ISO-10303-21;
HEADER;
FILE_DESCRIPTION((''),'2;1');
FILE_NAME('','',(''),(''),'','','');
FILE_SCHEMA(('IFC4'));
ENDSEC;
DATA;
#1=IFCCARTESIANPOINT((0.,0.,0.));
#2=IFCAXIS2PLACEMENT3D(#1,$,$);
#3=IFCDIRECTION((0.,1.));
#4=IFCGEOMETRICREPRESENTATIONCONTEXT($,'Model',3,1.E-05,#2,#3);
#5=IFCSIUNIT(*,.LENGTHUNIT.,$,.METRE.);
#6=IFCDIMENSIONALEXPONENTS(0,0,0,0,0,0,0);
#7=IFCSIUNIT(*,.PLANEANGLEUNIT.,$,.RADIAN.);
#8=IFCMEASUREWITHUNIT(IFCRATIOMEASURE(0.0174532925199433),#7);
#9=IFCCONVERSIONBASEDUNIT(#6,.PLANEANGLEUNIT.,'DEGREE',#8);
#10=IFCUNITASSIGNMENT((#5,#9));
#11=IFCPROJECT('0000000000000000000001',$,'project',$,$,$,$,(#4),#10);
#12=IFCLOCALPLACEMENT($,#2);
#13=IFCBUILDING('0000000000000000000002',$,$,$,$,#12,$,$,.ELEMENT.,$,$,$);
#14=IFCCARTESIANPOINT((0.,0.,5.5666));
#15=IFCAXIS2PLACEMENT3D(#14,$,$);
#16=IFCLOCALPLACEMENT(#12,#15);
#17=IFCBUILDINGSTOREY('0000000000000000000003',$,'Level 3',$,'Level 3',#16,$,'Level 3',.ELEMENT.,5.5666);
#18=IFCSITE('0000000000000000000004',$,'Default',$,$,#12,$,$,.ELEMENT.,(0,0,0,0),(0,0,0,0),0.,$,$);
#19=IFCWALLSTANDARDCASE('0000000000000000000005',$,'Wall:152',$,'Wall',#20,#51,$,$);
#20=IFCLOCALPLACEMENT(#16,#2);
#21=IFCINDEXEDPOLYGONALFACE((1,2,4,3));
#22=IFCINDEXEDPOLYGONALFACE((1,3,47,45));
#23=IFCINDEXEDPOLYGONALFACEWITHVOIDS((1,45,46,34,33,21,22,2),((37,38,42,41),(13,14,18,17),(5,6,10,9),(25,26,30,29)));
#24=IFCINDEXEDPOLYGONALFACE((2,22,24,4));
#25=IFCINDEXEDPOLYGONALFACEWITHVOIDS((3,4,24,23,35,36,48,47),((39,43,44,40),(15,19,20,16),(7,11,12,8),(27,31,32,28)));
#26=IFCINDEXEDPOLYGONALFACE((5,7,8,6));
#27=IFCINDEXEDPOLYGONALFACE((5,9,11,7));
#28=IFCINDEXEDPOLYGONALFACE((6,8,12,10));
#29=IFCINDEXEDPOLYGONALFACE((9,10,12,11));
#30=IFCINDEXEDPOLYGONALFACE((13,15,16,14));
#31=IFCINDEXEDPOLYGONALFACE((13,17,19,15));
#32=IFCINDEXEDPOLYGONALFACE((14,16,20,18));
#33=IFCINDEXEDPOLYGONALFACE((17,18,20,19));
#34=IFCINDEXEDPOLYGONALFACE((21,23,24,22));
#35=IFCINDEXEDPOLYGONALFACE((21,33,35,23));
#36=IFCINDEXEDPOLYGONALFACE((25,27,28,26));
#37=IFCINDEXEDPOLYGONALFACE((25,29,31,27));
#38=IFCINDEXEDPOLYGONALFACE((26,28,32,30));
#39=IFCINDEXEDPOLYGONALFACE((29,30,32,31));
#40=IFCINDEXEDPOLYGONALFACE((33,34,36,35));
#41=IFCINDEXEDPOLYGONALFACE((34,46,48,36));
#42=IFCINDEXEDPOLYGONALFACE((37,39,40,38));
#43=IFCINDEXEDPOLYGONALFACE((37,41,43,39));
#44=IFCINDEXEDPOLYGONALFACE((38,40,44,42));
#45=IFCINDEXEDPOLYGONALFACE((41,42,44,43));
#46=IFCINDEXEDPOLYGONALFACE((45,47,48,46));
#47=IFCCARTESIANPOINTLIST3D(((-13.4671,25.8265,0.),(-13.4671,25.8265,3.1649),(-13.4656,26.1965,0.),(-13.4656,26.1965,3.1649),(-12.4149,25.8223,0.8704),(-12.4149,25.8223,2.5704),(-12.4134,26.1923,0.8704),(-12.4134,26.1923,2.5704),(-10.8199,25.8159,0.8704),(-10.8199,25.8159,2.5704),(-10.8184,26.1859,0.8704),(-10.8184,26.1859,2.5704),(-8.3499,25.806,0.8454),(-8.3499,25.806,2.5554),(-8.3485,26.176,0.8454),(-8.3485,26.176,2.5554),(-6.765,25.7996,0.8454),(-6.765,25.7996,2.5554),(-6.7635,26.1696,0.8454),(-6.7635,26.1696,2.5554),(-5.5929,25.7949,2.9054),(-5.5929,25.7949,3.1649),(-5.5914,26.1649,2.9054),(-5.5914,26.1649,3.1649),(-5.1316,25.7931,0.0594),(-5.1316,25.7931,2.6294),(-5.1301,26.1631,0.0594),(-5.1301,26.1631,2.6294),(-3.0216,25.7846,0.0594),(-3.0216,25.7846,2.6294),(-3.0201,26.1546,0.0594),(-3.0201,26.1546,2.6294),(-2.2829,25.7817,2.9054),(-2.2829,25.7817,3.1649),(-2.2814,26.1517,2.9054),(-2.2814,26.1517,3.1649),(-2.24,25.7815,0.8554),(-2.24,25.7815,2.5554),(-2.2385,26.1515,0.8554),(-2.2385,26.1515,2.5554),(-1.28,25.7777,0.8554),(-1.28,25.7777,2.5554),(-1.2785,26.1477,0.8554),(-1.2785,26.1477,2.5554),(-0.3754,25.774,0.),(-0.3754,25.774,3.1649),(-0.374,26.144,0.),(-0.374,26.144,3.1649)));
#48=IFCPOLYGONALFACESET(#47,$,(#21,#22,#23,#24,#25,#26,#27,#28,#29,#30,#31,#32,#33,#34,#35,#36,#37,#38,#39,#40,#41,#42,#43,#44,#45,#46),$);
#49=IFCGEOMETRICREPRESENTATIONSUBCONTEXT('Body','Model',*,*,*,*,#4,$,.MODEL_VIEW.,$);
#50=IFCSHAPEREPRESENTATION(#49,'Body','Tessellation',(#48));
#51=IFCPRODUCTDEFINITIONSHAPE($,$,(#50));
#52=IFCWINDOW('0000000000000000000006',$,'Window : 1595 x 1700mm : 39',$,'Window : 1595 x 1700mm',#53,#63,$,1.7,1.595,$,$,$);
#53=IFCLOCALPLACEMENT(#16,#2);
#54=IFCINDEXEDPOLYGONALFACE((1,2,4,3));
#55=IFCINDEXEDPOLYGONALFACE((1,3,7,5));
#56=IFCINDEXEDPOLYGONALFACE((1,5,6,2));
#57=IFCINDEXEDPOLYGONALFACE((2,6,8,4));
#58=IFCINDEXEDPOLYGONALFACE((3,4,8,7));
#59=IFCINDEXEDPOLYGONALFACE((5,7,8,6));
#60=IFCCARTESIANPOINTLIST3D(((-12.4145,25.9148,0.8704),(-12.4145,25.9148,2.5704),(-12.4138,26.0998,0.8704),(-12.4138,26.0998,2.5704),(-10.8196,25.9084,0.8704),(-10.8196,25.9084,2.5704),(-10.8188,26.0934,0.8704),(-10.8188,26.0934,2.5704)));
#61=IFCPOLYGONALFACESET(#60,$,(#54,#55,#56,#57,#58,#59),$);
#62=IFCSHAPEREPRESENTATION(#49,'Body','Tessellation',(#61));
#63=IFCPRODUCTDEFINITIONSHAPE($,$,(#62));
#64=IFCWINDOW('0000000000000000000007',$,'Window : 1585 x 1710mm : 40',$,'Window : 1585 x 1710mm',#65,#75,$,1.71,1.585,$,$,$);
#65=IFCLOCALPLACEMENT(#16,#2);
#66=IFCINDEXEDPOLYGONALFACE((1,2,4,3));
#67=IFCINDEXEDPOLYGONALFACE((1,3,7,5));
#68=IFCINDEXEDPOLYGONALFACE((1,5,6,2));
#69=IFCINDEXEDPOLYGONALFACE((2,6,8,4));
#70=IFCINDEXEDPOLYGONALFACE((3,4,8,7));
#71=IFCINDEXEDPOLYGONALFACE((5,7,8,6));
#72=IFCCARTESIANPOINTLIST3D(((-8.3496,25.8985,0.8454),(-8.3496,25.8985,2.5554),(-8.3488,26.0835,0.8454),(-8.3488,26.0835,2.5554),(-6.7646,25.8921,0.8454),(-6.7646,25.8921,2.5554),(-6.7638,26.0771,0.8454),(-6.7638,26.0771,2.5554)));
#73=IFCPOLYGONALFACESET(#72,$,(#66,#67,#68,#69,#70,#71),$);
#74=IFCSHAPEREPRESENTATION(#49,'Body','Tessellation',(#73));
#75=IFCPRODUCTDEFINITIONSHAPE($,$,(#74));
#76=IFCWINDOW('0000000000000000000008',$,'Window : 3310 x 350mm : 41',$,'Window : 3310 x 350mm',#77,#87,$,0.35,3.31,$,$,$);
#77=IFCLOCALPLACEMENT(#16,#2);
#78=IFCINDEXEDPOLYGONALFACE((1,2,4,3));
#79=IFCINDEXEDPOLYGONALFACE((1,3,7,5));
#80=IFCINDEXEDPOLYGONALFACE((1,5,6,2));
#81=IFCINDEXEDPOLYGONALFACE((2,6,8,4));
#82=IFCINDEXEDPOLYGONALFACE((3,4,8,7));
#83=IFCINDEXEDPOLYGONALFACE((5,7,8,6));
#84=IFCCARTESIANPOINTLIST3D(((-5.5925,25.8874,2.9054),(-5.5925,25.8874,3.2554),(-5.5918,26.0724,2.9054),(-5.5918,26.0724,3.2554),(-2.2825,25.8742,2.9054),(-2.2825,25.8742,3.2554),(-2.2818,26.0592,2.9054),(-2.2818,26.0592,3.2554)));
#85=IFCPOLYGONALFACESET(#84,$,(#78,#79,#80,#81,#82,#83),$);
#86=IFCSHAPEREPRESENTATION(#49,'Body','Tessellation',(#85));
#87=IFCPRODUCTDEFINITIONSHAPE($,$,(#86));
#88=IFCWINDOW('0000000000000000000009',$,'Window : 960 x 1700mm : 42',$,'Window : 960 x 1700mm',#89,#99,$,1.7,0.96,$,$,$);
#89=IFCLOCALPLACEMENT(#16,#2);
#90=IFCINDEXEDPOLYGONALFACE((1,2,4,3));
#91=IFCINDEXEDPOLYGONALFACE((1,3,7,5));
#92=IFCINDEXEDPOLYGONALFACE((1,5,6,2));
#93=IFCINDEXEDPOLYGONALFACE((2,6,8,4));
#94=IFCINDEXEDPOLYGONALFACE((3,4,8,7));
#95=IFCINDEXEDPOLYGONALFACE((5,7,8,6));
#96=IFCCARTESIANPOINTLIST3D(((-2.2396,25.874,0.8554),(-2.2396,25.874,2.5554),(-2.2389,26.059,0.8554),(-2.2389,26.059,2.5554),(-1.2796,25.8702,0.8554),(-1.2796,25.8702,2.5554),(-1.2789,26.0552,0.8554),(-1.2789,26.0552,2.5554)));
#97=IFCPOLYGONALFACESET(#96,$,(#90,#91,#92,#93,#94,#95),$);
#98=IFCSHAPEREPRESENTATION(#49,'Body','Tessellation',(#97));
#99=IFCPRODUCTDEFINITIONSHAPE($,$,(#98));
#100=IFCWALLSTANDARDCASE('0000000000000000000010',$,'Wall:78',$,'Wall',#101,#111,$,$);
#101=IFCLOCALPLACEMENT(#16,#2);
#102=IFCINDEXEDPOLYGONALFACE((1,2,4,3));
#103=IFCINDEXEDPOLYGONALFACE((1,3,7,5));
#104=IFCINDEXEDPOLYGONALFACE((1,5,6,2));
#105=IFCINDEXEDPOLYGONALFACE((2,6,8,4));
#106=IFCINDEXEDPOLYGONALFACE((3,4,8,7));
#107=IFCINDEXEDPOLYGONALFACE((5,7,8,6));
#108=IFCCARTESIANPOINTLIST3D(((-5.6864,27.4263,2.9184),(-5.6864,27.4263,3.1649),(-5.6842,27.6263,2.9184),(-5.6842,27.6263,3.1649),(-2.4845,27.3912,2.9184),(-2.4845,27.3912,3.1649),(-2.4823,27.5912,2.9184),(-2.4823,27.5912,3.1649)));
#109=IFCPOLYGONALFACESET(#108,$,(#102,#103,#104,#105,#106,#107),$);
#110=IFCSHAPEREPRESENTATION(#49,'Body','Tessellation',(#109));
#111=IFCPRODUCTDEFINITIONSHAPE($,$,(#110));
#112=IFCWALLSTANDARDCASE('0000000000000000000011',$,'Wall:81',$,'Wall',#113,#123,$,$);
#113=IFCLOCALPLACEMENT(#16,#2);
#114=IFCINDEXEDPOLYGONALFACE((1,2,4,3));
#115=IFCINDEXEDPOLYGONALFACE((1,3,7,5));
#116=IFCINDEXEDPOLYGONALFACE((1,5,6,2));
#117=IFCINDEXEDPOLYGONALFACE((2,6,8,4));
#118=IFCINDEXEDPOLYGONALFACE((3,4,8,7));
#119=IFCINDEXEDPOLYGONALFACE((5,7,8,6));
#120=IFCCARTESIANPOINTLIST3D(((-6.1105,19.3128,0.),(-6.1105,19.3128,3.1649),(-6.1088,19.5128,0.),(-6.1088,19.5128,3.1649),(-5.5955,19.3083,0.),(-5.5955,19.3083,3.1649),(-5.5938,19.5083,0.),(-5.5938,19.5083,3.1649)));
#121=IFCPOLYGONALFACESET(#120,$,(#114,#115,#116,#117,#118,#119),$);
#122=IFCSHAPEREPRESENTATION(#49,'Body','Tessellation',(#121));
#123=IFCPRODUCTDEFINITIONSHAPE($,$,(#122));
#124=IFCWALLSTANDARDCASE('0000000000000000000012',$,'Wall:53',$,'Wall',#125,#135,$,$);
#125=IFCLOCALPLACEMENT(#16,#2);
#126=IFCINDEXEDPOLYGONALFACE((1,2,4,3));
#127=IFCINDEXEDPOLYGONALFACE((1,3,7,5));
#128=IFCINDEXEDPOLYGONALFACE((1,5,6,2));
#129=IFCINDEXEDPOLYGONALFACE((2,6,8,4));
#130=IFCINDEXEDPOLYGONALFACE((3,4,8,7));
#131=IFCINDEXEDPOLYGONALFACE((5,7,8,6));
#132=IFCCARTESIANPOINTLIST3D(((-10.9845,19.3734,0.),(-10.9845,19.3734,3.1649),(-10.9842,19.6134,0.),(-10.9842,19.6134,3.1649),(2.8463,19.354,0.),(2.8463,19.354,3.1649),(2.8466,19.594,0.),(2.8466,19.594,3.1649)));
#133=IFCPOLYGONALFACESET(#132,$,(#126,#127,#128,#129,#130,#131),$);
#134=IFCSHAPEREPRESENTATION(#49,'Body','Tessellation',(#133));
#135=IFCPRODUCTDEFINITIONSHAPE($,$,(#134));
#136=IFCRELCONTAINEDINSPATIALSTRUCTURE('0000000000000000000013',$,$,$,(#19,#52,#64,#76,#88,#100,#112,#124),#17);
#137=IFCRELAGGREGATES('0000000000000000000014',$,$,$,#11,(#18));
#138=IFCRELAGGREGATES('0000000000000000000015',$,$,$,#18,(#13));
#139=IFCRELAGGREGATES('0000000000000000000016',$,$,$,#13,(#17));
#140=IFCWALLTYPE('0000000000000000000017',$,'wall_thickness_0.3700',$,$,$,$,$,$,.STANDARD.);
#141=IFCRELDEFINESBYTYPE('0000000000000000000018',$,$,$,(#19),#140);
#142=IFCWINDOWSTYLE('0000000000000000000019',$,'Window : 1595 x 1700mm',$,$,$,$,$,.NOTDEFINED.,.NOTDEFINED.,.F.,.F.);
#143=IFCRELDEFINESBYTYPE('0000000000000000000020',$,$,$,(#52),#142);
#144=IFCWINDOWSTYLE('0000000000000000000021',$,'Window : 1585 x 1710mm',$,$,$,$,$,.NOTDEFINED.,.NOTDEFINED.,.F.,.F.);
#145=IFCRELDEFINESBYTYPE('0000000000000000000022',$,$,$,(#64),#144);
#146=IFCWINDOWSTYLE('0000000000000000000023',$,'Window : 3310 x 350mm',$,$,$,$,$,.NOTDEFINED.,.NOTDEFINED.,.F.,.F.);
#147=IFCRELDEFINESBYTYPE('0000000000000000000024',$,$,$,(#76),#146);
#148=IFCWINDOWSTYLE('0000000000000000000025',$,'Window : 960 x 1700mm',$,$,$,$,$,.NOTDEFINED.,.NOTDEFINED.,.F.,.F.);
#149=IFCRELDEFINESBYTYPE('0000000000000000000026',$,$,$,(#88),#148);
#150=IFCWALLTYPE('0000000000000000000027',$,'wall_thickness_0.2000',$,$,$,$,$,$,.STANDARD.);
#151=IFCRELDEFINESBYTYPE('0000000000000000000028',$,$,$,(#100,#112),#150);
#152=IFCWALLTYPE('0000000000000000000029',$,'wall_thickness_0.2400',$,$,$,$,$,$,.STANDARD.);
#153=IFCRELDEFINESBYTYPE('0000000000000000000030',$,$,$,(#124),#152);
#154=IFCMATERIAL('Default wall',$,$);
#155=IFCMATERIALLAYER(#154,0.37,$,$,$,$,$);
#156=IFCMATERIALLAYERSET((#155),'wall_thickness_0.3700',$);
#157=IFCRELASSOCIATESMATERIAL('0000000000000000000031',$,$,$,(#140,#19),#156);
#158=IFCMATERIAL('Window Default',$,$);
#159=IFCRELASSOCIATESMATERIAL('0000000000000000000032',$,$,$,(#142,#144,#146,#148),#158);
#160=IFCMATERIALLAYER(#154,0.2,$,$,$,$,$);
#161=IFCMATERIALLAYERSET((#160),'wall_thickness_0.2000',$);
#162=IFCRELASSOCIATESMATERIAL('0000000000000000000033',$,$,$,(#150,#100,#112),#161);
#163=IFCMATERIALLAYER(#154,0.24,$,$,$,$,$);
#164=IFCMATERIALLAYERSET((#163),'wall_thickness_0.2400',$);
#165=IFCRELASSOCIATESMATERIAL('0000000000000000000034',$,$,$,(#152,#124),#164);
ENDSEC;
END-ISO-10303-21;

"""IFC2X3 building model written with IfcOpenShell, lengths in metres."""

from ifc_helpers import new_model, entity, si_unit, converted_unit, direction, frame, frame_2d, origin, origin_2d_with_axis, place, context, subcontext, project, spatial, polyline, rectangle, outline, extrude, source, transform, mapped, material, layer, layer_set, layer_usage, type_object, type_shapes, element, fill, save


model = new_model("IFC2X3")

# Units and contexts
model_context = context("Model", 3, precision=1e-05, world=origin(), true_north=direction((0.0, 1.0)))
body_context = subcontext(model_context, "Body", "Model", "MODEL_VIEW")
ifc_project = project(units=[si_unit("LENGTHUNIT", "METRE"), converted_unit("PLANEANGLEUNIT", "DEGREE", entity("IfcRatioMeasure", 0.0174532925199433), si_unit("PLANEANGLEUNIT", "RADIAN"), dimensions=[0, 0, 0, 0, 0, 0, 0])], contexts=[model_context])

# Site, building, storey
placement_1 = place(None, origin())
site = spatial("IfcSite", under=ifc_project, at=placement_1, Name="Default", CompositionType="ELEMENT", RefLatitude=(0, 0, 0, 0), RefLongitude=(0, 0, 0, 0), RefElevation=0.0)
building = spatial("IfcBuilding", under=site, at=placement_1, CompositionType="ELEMENT")
storey_placement = place(placement_1, frame((0.0, 0.0, 5.5666)))
storey = spatial("IfcBuildingStorey", under=building, at=storey_placement, Name="Level 3", ObjectType="Level 3", LongName="Level 3", CompositionType="ELEMENT", Elevation=5.5666)

# Shared definitions
ifc_material_1 = material(Name="Default wall")

# Shared definitions
ifc_material_2 = material(Name="Window Default")

# Wall, openings, windows
ifc_layer_1 = layer(ifc_material_1, 0.37)
ifc_layer_set_1 = layer_set([ifc_layer_1], Name="wall_thickness_0.3700")
ifc_layer_usage_1 = layer_usage(ifc_layer_set_1, "AXIS2", "POSITIVE", -0.185)
wall_type_1 = type_object("IfcWallType", Name="wall_thickness_0.3700", PredefinedType="STANDARD", material=ifc_layer_set_1)
wall_1_placement = place(storey_placement, frame((-13.4664, 26.0115, 0.0), z_axis=(0.0, 0.0, 1.0), x_axis=(0.999992, -0.004006, 0.0)))
wall_1 = element("IfcWallStandardCase", 1, at=wall_1_placement, inside=storey, type_object=wall_type_1, material=ifc_layer_usage_1, Name="Wall:152", ObjectType="Wall", context=body_context, shape_type="SweptSolid", body=[
    extrude(outline(polyline([(13.0918, -0.185), (13.0918, 0.185), (0.0, 0.185), (0.0, -0.185), (13.0918, -0.185)])), origin(), (0.0, 0.0, 1.0), 3.1649),
])
opening_1_placement = place(wall_1_placement, frame((8.3356, -0.185, 0.0594)))
element("IfcOpeningElement", 2, at=opening_1_placement, cuts=wall_1, ObjectType="Opening", context=body_context, shape_type="SweptSolid", body=[
    extrude(rectangle(XDim=2.11, YDim=2.57, at=frame_2d((1.285, 1.055), x_axis=(0.0, 1.0))), frame((0.0, 0.0, 0.0), z_axis=(0.0, 1.0, 0.0), x_axis=(0.0, 0.0, 1.0)), (0.0, 0.0, 1.0), 0.37),
])
opening_2_placement = place(wall_1_placement, frame((1.0522, -0.185, 0.8704)))
opening_2 = element("IfcOpeningElement", 3, at=opening_2_placement, cuts=wall_1, ObjectType="Opening", context=body_context, shape_type="SweptSolid", body=[
    extrude(rectangle(XDim=1.595, YDim=1.7, at=frame_2d((0.85, 0.7975), x_axis=(0.0, 1.0))), frame((0.0, 0.0, 0.0), z_axis=(0.0, 1.0, 0.0), x_axis=(0.0, 0.0, 1.0)), (0.0, 0.0, 1.0), 0.37),
])
opening_3_placement = place(wall_1_placement, frame((5.1172, -0.185, 0.8454)))
opening_3 = element("IfcOpeningElement", 4, at=opening_3_placement, cuts=wall_1, ObjectType="Opening", context=body_context, shape_type="SweptSolid", body=[
    extrude(rectangle(XDim=1.585, YDim=1.71, at=frame_2d((0.855, 0.7925), x_axis=(0.0, 1.0))), frame((0.0, 0.0, 0.0), z_axis=(0.0, 1.0, 0.0), x_axis=(0.0, 0.0, 1.0)), (0.0, 0.0, 1.0), 0.37),
])
opening_4_placement = place(wall_1_placement, frame((7.8743, -0.185, 2.9054)))
opening_4 = element("IfcOpeningElement", 5, at=opening_4_placement, cuts=wall_1, ObjectType="Opening", context=body_context, shape_type="SweptSolid", body=[
    extrude(rectangle(XDim=3.31, YDim=0.35, at=frame_2d((0.175, 1.655), x_axis=(0.0, 1.0))), frame((0.0, 0.0, 0.0), z_axis=(0.0, 1.0, 0.0), x_axis=(0.0, 0.0, 1.0)), (0.0, 0.0, 1.0), 0.37),
])
opening_5_placement = place(wall_1_placement, frame((11.2272, -0.185, 0.8554)))
opening_5 = element("IfcOpeningElement", 6, at=opening_5_placement, cuts=wall_1, ObjectType="Opening", context=body_context, shape_type="SweptSolid", body=[
    extrude(rectangle(XDim=0.96, YDim=1.7, at=frame_2d((0.85, 0.48), x_axis=(0.0, 1.0))), frame((0.0, 0.0, 0.0), z_axis=(0.0, 1.0, 0.0), x_axis=(0.0, 0.0, 1.0)), (0.0, 0.0, 1.0), 0.37),
])
window_style_1 = type_object("IfcWindowStyle", Name="Window : 1595 x 1700mm", ConstructionType="NOTDEFINED", OperationType="NOTDEFINED", ParameterTakesPrecedence=False, Sizeable=False, material=ifc_material_2)
shared_shape_1 = source(origin(), body_context, "Body", "SweptSolid", [
    extrude(rectangle(XDim=0.185, YDim=1.595, at=origin_2d_with_axis()), frame((0.7975, 0.185, 0.0), z_axis=(0.0, 0.0, 1.0), x_axis=(0.0, 1.0, 0.0)), (0.0, 0.0, 1.0), 1.7),
])
type_shapes(window_style_1, [shared_shape_1])
window_1_placement = place(opening_2_placement, origin())
window_1 = element("IfcWindow", 7, at=window_1_placement, inside=storey, type_object=window_style_1, Name="Window : 1595 x 1700mm : 39", ObjectType="Window : 1595 x 1700mm", OverallHeight=1.7, OverallWidth=1.595, context=body_context, shape_type="MappedRepresentation", body=[
    mapped(shared_shape_1, transform((0.0, 0.0, 0.0), scale=1.0)),
])
fill(opening_2, window_1)
window_style_2 = type_object("IfcWindowStyle", Name="Window : 1585 x 1710mm", ConstructionType="NOTDEFINED", OperationType="NOTDEFINED", ParameterTakesPrecedence=False, Sizeable=False, material=ifc_material_2)
shared_shape_2 = source(origin(), body_context, "Body", "SweptSolid", [
    extrude(rectangle(XDim=0.185, YDim=1.585, at=origin_2d_with_axis()), frame((0.7925, 0.185, 0.0), z_axis=(0.0, 0.0, 1.0), x_axis=(0.0, 1.0, 0.0)), (0.0, 0.0, 1.0), 1.71),
])
type_shapes(window_style_2, [shared_shape_2])
window_2_placement = place(opening_3_placement, origin())
window_2 = element("IfcWindow", 8, at=window_2_placement, inside=storey, type_object=window_style_2, Name="Window : 1585 x 1710mm : 40", ObjectType="Window : 1585 x 1710mm", OverallHeight=1.71, OverallWidth=1.585, context=body_context, shape_type="MappedRepresentation", body=[
    mapped(shared_shape_2, transform((0.0, 0.0, 0.0), scale=1.0)),
])
fill(opening_3, window_2)
window_style_3 = type_object("IfcWindowStyle", Name="Window : 3310 x 350mm", ConstructionType="NOTDEFINED", OperationType="NOTDEFINED", ParameterTakesPrecedence=False, Sizeable=False, material=ifc_material_2)
shared_shape_3 = source(origin(), body_context, "Body", "SweptSolid", [
    extrude(rectangle(XDim=0.185, YDim=3.31, at=origin_2d_with_axis()), frame((1.655, 0.185, 0.0), z_axis=(0.0, 0.0, 1.0), x_axis=(0.0, 1.0, 0.0)), (0.0, 0.0, 1.0), 0.35),
])
type_shapes(window_style_3, [shared_shape_3])
window_3_placement = place(opening_4_placement, origin())
window_3 = element("IfcWindow", 9, at=window_3_placement, inside=storey, type_object=window_style_3, Name="Window : 3310 x 350mm : 41", ObjectType="Window : 3310 x 350mm", OverallHeight=0.35, OverallWidth=3.31, context=body_context, shape_type="MappedRepresentation", body=[
    mapped(shared_shape_3, transform((0.0, 0.0, 0.0), scale=1.0)),
])
fill(opening_4, window_3)
window_style_4 = type_object("IfcWindowStyle", Name="Window : 960 x 1700mm", ConstructionType="NOTDEFINED", OperationType="NOTDEFINED", ParameterTakesPrecedence=False, Sizeable=False, material=ifc_material_2)
shared_shape_4 = source(origin(), body_context, "Body", "SweptSolid", [
    extrude(rectangle(XDim=0.185, YDim=0.96, at=origin_2d_with_axis()), frame((0.48, 0.185, 0.0), z_axis=(0.0, 0.0, 1.0), x_axis=(0.0, 1.0, 0.0)), (0.0, 0.0, 1.0), 1.7),
])
type_shapes(window_style_4, [shared_shape_4])
window_4_placement = place(opening_5_placement, origin())
window_4 = element("IfcWindow", 10, at=window_4_placement, inside=storey, type_object=window_style_4, Name="Window : 960 x 1700mm : 42", ObjectType="Window : 960 x 1700mm", OverallHeight=1.7, OverallWidth=0.96, context=body_context, shape_type="MappedRepresentation", body=[
    mapped(shared_shape_4, transform((0.0, 0.0, 0.0), scale=1.0)),
])
fill(opening_5, window_4)

# Walls
ifc_layer_2 = layer(ifc_material_1, 0.2)
ifc_layer_set_2 = layer_set([ifc_layer_2], Name="wall_thickness_0.2000")
ifc_layer_usage_2 = layer_usage(ifc_layer_set_2, "AXIS2", "POSITIVE", -0.1)
wall_type_2 = type_object("IfcWallType", Name="wall_thickness_0.2000", PredefinedType="STANDARD", material=ifc_layer_set_2)
placement_2 = place(placement_1, frame((0.0, 0.0, 8.485)))
wall_2_placement = place(placement_2, frame((-5.6853, 27.5263, 0.0), z_axis=(0.0, 0.0, 1.0), x_axis=(0.99994, -0.010944, 0.0)))
element("IfcWallStandardCase", 11, at=wall_2_placement, inside=storey, type_object=wall_type_2, material=ifc_layer_usage_2, Name="Wall:78", ObjectType="Wall", context=body_context, shape_type="SweptSolid", body=[
    extrude(outline(polyline([(3.202, -0.1), (3.202, 0.1), (0.0, 0.1), (0.0, -0.1), (3.202, -0.1)])), origin(), (0.0, 0.0, 1.0), 0.2465),
])
wall_3_placement = place(storey_placement, frame((-6.1097, 19.4128, 0.0), z_axis=(0.0, 0.0, 1.0), x_axis=(0.999962, -0.008726, 0.0)))
element("IfcWallStandardCase", 12, at=wall_3_placement, inside=storey, type_object=wall_type_2, material=ifc_layer_usage_2, Name="Wall:81", ObjectType="Wall", context=body_context, shape_type="SweptSolid", body=[
    extrude(outline(polyline([(0.515, -0.1), (0.515, 0.1), (0.0, 0.1), (0.0, -0.1), (0.515, -0.1)])), origin(), (0.0, 0.0, 1.0), 3.1649),
])
ifc_layer_3 = layer(ifc_material_1, 0.24)
ifc_layer_set_3 = layer_set([ifc_layer_3], Name="wall_thickness_0.2400")
ifc_layer_usage_3 = layer_usage(ifc_layer_set_3, "AXIS2", "POSITIVE", -0.12)
wall_type_3 = type_object("IfcWallType", Name="wall_thickness_0.2400", PredefinedType="STANDARD", material=ifc_layer_set_3)
wall_4_placement = place(storey_placement, frame((-10.9843, 19.4934, 0.0), z_axis=(0.0, 0.0, 1.0), x_axis=(0.999999, -0.001399, 0.0)))
element("IfcWallStandardCase", 13, at=wall_4_placement, inside=storey, type_object=wall_type_3, material=ifc_layer_usage_3, Name="Wall:53", ObjectType="Wall", context=body_context, shape_type="SweptSolid", body=[
    extrude(outline(polyline([(13.8308, -0.12), (13.8308, 0.12), (0.0, 0.12), (0.0, -0.12), (13.8308, -0.12)])), origin(), (0.0, 0.0, 1.0), 3.1649),
])

save(model, "model.ifc")
